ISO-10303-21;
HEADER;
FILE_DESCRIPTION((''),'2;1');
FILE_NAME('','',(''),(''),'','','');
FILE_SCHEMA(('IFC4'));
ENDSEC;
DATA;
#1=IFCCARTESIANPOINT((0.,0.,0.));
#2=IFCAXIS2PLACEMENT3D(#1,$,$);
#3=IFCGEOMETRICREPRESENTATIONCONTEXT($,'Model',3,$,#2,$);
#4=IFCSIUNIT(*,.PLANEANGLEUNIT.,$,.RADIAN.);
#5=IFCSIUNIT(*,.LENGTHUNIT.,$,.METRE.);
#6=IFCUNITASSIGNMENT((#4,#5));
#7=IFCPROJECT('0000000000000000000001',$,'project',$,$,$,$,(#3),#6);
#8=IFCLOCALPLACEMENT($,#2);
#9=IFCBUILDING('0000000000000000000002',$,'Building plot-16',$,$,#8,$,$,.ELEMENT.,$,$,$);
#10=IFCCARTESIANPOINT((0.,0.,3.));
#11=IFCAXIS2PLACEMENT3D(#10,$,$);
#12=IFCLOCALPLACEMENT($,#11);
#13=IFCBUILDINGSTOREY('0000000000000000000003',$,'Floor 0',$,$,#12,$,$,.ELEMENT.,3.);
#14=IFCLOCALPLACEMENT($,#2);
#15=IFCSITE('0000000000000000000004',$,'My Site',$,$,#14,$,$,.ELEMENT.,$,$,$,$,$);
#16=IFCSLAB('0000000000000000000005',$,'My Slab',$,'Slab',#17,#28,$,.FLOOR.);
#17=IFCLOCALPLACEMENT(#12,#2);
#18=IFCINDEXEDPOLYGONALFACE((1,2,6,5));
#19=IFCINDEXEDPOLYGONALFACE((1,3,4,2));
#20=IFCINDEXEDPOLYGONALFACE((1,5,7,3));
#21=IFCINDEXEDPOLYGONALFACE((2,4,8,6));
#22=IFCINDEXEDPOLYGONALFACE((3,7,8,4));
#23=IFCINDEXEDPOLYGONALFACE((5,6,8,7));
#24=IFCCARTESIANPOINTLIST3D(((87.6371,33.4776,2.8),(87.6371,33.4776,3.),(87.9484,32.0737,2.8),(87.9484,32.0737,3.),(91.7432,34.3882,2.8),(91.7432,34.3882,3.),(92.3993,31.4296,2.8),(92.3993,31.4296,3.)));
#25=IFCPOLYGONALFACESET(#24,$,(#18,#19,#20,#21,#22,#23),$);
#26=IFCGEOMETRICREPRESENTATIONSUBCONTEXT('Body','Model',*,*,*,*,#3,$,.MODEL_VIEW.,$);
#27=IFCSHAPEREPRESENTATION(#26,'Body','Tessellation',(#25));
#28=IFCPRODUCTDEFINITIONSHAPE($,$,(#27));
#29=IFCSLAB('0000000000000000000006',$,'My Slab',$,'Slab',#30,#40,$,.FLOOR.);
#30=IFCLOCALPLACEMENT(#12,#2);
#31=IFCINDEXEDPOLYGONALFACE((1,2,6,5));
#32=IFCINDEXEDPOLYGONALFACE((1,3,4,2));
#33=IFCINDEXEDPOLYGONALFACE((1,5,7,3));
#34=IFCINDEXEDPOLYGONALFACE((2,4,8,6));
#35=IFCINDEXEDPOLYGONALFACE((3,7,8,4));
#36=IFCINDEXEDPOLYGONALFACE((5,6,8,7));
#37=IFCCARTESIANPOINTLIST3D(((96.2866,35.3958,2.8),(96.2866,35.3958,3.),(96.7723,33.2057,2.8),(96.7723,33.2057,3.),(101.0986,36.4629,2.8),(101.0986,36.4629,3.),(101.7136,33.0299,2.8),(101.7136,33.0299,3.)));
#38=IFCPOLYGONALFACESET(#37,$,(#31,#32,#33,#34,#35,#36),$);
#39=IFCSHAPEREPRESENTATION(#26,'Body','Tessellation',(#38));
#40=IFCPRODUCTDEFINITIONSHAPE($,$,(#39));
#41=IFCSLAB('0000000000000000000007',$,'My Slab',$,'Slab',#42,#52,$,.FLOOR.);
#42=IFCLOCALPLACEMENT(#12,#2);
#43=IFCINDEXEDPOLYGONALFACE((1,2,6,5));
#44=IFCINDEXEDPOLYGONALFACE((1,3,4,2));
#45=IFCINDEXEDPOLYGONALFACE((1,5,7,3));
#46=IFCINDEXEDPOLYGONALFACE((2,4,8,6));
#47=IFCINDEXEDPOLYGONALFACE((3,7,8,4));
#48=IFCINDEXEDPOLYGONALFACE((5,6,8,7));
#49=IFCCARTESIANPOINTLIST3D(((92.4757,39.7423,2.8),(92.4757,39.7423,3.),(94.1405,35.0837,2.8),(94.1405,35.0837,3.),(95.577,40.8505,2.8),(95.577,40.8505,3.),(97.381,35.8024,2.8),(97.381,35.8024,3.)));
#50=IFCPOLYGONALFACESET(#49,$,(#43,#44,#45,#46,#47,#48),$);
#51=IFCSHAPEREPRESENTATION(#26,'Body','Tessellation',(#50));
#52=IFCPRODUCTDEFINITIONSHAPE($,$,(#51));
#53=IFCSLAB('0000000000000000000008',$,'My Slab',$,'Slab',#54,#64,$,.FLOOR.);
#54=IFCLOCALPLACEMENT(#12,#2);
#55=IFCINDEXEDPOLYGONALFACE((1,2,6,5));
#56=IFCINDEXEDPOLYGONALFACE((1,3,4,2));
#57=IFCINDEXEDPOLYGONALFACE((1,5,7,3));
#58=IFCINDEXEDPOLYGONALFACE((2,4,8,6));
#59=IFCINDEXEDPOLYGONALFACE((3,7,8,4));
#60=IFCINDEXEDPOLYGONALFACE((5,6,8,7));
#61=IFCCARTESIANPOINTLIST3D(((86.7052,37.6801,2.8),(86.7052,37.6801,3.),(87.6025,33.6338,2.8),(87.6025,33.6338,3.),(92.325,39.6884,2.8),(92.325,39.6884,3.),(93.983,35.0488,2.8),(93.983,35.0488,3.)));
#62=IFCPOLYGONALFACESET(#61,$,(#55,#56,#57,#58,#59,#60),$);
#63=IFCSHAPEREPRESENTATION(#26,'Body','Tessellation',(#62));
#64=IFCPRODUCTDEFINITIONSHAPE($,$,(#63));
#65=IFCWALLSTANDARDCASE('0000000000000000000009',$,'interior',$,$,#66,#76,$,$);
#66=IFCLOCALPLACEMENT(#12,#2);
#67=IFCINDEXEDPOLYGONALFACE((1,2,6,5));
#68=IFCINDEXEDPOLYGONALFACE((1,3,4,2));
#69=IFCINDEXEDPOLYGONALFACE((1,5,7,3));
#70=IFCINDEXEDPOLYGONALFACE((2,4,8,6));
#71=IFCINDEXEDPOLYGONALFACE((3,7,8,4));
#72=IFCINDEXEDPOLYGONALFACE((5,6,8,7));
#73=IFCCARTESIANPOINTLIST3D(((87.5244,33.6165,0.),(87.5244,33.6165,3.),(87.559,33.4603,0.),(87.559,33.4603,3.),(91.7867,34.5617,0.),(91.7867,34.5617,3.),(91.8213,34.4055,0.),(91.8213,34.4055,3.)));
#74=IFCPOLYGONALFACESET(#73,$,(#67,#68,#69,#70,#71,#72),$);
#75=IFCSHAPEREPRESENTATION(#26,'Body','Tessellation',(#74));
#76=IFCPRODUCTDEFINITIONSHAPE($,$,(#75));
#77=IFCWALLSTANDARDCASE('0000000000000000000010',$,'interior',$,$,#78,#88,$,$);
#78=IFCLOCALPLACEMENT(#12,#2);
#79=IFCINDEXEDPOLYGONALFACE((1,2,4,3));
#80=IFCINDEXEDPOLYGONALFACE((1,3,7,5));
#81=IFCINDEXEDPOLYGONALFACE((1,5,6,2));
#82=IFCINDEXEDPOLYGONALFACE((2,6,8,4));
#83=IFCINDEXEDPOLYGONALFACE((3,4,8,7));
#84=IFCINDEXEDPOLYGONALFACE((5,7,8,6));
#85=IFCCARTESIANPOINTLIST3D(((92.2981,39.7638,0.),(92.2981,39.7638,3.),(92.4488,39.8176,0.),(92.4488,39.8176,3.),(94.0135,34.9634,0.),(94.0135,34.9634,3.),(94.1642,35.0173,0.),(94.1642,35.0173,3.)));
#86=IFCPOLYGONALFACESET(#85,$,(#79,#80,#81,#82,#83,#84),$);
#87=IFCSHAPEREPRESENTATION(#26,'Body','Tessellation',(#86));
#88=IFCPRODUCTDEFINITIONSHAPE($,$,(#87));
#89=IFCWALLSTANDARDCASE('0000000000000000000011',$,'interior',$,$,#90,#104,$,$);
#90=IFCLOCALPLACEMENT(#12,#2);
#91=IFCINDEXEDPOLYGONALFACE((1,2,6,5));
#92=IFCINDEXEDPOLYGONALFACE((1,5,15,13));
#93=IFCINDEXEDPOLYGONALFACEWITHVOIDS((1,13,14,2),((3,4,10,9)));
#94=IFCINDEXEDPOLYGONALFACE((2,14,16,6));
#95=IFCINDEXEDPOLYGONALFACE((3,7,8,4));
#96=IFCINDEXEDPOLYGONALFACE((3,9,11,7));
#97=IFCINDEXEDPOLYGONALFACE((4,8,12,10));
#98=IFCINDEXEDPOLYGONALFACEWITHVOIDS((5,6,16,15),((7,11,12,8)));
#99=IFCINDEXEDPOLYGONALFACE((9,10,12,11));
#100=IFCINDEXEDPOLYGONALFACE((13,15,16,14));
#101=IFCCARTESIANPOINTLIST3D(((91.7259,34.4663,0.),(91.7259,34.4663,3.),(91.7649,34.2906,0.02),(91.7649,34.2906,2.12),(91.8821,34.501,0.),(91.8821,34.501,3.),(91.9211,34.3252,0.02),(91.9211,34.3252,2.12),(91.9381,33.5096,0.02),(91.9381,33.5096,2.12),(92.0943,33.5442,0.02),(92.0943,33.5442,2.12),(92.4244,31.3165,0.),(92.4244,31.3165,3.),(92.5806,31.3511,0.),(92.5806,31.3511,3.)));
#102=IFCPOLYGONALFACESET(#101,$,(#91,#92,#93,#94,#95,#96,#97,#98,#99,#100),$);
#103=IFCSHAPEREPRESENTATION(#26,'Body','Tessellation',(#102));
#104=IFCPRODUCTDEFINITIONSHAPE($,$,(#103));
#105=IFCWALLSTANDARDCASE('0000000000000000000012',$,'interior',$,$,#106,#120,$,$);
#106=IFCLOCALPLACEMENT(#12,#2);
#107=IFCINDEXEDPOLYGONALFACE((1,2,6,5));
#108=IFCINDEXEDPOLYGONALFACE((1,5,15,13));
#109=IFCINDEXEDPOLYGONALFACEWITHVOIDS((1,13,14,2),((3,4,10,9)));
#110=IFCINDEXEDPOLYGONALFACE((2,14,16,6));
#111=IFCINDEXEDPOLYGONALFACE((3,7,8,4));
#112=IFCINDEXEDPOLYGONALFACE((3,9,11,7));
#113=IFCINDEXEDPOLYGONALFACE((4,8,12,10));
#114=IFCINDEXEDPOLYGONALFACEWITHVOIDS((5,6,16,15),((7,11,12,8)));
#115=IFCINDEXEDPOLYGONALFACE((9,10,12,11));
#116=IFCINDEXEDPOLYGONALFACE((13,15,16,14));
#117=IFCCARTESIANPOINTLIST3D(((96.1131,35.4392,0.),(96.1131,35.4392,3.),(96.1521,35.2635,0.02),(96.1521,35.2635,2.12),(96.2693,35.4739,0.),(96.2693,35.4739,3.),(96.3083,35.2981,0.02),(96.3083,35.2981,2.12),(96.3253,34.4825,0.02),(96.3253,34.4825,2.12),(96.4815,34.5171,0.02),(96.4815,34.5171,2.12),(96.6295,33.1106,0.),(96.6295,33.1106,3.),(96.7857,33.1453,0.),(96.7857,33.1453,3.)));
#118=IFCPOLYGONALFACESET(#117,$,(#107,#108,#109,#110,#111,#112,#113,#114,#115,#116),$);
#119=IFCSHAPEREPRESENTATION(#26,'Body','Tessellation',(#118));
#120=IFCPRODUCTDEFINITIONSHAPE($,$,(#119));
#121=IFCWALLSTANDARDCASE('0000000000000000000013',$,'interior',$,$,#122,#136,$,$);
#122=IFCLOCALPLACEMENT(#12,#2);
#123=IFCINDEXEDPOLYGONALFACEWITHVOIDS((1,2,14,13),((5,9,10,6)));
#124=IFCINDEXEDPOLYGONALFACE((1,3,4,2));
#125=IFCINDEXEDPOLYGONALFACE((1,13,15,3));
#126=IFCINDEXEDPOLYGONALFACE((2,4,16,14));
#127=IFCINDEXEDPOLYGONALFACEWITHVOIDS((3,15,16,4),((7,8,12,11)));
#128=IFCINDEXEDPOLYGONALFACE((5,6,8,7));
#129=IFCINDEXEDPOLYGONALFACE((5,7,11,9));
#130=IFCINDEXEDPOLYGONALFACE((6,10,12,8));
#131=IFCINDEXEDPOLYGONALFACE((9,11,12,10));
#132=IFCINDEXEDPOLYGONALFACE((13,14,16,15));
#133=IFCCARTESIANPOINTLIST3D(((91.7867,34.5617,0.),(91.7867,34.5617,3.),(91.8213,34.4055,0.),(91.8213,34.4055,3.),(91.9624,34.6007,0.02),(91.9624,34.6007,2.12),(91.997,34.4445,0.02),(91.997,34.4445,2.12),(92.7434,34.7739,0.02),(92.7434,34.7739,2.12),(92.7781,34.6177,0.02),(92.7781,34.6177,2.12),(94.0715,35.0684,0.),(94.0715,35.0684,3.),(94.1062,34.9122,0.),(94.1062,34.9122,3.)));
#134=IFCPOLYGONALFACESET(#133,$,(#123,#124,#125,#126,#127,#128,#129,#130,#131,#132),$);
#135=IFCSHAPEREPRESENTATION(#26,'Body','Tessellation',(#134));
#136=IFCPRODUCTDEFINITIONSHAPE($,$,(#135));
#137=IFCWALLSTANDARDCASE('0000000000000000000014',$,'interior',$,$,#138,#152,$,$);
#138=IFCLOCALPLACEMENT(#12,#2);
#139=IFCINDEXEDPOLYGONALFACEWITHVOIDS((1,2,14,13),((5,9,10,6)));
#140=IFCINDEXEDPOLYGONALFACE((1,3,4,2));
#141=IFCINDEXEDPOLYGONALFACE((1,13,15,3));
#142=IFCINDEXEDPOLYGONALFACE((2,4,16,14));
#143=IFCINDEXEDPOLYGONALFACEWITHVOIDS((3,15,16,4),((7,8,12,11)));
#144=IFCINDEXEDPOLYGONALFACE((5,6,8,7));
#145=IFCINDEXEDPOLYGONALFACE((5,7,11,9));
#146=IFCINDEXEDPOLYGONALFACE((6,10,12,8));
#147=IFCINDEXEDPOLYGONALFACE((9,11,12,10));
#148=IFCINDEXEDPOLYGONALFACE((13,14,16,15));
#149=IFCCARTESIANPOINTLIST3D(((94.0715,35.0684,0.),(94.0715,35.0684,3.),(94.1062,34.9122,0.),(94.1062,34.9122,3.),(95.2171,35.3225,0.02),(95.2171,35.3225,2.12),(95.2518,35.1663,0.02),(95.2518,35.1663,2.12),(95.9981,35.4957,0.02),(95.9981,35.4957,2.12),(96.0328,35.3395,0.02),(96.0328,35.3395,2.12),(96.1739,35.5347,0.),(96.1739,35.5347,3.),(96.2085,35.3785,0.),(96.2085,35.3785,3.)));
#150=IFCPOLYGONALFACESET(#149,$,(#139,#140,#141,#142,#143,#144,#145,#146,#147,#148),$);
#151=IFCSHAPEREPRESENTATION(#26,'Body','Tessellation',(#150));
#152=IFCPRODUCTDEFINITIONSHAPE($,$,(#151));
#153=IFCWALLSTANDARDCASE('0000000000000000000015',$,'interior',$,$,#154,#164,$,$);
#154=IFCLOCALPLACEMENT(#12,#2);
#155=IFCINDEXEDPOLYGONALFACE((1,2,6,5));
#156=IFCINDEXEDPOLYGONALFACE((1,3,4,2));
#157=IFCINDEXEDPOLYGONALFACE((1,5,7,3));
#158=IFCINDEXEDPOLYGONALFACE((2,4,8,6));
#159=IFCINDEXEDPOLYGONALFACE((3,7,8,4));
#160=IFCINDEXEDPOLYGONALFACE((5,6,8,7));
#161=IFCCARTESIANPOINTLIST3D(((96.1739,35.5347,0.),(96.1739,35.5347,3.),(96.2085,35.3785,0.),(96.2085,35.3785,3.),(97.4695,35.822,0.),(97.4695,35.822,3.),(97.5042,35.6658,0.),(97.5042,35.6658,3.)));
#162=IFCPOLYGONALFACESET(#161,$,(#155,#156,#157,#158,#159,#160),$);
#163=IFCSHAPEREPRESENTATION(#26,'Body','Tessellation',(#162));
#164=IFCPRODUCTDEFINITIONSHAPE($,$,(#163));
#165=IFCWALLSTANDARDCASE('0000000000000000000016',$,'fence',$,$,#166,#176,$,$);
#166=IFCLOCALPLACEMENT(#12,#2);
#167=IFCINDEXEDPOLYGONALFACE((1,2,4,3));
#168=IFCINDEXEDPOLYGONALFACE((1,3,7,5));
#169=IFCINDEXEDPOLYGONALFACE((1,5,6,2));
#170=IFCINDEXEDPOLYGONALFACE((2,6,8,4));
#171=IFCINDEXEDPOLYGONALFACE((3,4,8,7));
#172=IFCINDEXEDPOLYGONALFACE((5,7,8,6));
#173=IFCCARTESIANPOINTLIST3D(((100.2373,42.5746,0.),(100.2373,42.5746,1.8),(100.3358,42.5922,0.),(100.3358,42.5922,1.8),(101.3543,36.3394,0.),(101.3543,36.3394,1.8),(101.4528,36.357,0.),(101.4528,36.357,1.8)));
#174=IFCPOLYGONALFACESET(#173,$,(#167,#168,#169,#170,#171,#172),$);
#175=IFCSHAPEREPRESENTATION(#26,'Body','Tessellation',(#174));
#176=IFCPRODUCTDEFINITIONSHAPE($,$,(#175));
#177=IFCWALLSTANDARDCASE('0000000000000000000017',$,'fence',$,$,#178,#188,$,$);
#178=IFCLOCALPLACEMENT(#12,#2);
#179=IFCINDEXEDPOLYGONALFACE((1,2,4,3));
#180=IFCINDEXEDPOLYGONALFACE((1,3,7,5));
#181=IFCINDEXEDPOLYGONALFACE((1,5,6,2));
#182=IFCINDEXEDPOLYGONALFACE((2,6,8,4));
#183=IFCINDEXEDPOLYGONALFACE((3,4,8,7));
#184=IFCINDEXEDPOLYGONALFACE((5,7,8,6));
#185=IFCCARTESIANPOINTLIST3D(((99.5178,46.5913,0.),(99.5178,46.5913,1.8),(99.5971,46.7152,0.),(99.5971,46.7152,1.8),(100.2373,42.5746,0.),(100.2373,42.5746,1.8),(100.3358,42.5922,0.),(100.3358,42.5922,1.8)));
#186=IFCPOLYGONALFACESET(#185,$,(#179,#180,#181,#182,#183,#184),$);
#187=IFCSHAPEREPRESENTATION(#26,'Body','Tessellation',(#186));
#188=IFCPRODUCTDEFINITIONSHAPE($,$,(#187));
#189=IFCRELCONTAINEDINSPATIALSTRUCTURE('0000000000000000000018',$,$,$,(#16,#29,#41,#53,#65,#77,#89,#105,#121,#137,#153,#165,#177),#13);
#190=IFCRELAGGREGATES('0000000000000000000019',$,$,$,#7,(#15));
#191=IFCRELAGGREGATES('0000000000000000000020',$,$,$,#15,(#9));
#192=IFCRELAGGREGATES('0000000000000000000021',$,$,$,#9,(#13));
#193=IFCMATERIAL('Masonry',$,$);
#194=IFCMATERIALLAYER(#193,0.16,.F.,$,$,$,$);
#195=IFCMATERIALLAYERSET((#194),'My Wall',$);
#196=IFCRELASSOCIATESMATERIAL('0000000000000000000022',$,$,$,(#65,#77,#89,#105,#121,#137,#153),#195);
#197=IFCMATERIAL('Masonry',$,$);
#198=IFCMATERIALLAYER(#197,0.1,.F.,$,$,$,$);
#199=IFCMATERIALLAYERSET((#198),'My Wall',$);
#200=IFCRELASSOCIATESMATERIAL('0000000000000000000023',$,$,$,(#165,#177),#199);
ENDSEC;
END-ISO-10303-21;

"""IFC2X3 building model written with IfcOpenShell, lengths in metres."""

from ifc_helpers import new_model, si_unit, frame, origin, place, context, subcontext, project, spatial, polyline, outline, extrude, material, layer, layer_set, layer_usage, element, save


model = new_model("IFC2X3")

# Units and contexts
model_context = context("Model", 3, world=origin())
body_context = subcontext(model_context, "Body", "Model", "MODEL_VIEW")
ifc_project = project(units=[si_unit("PLANEANGLEUNIT", "RADIAN"), si_unit("LENGTHUNIT", "METRE")], contexts=[model_context])

# Site, building, storey
site_placement = place(None, origin())
site = spatial("IfcSite", under=ifc_project, at=site_placement, Name="My Site", CompositionType="ELEMENT")
building_placement = place(None, origin())
building = spatial("IfcBuilding", under=site, at=building_placement, Name="Building plot-16", CompositionType="ELEMENT")
storey_placement = place(None, frame((0.0, 0.0, 3.0)))
storey = spatial("IfcBuildingStorey", under=building, at=storey_placement, Name="Floor 0", CompositionType="ELEMENT", Elevation=3.0)

# Slabs
slab_1_placement = place(storey_placement, frame((0.0, 0.0, 2.8)))
element("IfcSlab", 1, at=slab_1_placement, inside=storey, Name="My Slab", ObjectType="Slab", PredefinedType="FLOOR", context=body_context, shape_type="SweptSolid", body=[
    extrude(outline(polyline([(91.7432, 34.3882), (87.6371, 33.4776), (87.9484, 32.0737), (92.3993, 31.4296), (91.7432, 34.3882)])), origin(), (0.0, 0.0, 1.0), 0.2),
])
slab_2_placement = place(storey_placement, frame((0.0, 0.0, 2.8)))
element("IfcSlab", 2, at=slab_2_placement, inside=storey, Name="My Slab", ObjectType="Slab", PredefinedType="FLOOR", context=body_context, shape_type="SweptSolid", body=[
    extrude(outline(polyline([(96.2866, 35.3958), (96.7723, 33.2057), (101.7136, 33.0299), (101.0986, 36.4629), (96.2866, 35.3958)])), origin(), (0.0, 0.0, 1.0), 0.2),
])
slab_3_placement = place(storey_placement, frame((0.0, 0.0, 2.8)))
element("IfcSlab", 3, at=slab_3_placement, inside=storey, Name="My Slab", ObjectType="Slab", PredefinedType="FLOOR", context=body_context, shape_type="SweptSolid", body=[
    extrude(outline(polyline([(94.1405, 35.0837), (97.381, 35.8024), (95.577, 40.8505), (92.4757, 39.7423), (94.1405, 35.0837)])), origin(), (0.0, 0.0, 1.0), 0.2),
])
slab_4_placement = place(storey_placement, frame((0.0, 0.0, 2.8)))
element("IfcSlab", 4, at=slab_4_placement, inside=storey, Name="My Slab", ObjectType="Slab", PredefinedType="FLOOR", context=body_context, shape_type="SweptSolid", body=[
    extrude(outline(polyline([(87.6025, 33.6338), (93.983, 35.0488), (92.325, 39.6884), (86.7052, 37.6801), (87.6025, 33.6338)])), origin(), (0.0, 0.0, 1.0), 0.2),
])

# Walls
ifc_material_1 = material(Name="Masonry")
ifc_layer_1 = layer(ifc_material_1, 0.16, ventilated=False)
ifc_layer_set_1 = layer_set([ifc_layer_1], Name="My Wall")
ifc_layer_usage_1 = layer_usage(ifc_layer_set_1, "AXIS2", "NEGATIVE", 0.08)
wall_1_placement = place(storey_placement, origin())
element("IfcWallStandardCase", 5, at=wall_1_placement, inside=storey, material=ifc_layer_usage_1, Name="interior", context=body_context, shape_type="SweptSolid", body=[
    extrude(outline(polyline([(91.8213, 34.4055), (91.7867, 34.5617), (87.5244, 33.6165), (87.559, 33.4603), (91.8213, 34.4055)])), origin(), (0.0, 0.0, 1.0), 3.0),
])
wall_2_placement = place(storey_placement, origin())
element("IfcWallStandardCase", 6, at=wall_2_placement, inside=storey, material=ifc_layer_usage_1, Name="interior", context=body_context, shape_type="SweptSolid", body=[
    extrude(outline(polyline([(92.4488, 39.8176), (92.2981, 39.7638), (94.0135, 34.9634), (94.1642, 35.0173), (92.4488, 39.8176)])), origin(), (0.0, 0.0, 1.0), 3.0),
])

# Walls, openings
wall_3_placement = place(storey_placement, origin())
wall_3 = element("IfcWallStandardCase", 7, at=wall_3_placement, inside=storey, material=ifc_layer_usage_1, Name="interior", context=body_context, shape_type="SweptSolid", body=[
    extrude(outline(polyline([(91.8821, 34.501), (91.7259, 34.4663), (92.4244, 31.3165), (92.5806, 31.3511), (91.8821, 34.501)])), origin(), (0.0, 0.0, 1.0), 3.0),
])
opening_1_placement = place(storey_placement, frame((0.0, 0.0, 0.02)))
element("IfcOpeningElement", 8, at=opening_1_placement, cuts=wall_3, ObjectType="Opening", context=body_context, shape_type="SweptSolid", body=[
    extrude(outline(polyline([(91.7649, 34.2906), (91.9381, 33.5096), (92.0943, 33.5442), (91.9211, 34.3252), (91.7649, 34.2906)])), origin(), (0.0, 0.0, 1.0), 2.1),
])
wall_4_placement = place(storey_placement, origin())
wall_4 = element("IfcWallStandardCase", 9, at=wall_4_placement, inside=storey, material=ifc_layer_usage_1, Name="interior", context=body_context, shape_type="SweptSolid", body=[
    extrude(outline(polyline([(96.2693, 35.4739), (96.1131, 35.4392), (96.6295, 33.1106), (96.7857, 33.1453), (96.2693, 35.4739)])), origin(), (0.0, 0.0, 1.0), 3.0),
])
opening_2_placement = place(storey_placement, frame((0.0, 0.0, 0.02)))
element("IfcOpeningElement", 10, at=opening_2_placement, cuts=wall_4, ObjectType="Opening", context=body_context, shape_type="SweptSolid", body=[
    extrude(outline(polyline([(96.1521, 35.2635), (96.3253, 34.4825), (96.4815, 34.5171), (96.3083, 35.2981), (96.1521, 35.2635)])), origin(), (0.0, 0.0, 1.0), 2.1),
])
wall_5_placement = place(storey_placement, origin())
wall_5 = element("IfcWallStandardCase", 11, at=wall_5_placement, inside=storey, material=ifc_layer_usage_1, Name="interior", context=body_context, shape_type="SweptSolid", body=[
    extrude(outline(polyline([(94.1062, 34.9122), (94.0715, 35.0684), (91.7867, 34.5617), (91.8213, 34.4055), (94.1062, 34.9122)])), origin(), (0.0, 0.0, 1.0), 3.0),
])
opening_3_placement = place(storey_placement, frame((0.0, 0.0, 0.02)))
element("IfcOpeningElement", 12, at=opening_3_placement, cuts=wall_5, ObjectType="Opening", context=body_context, shape_type="SweptSolid", body=[
    extrude(outline(polyline([(92.7434, 34.7739), (91.9624, 34.6007), (91.997, 34.4445), (92.7781, 34.6177), (92.7434, 34.7739)])), origin(), (0.0, 0.0, 1.0), 2.1),
])
wall_6_placement = place(storey_placement, origin())
wall_6 = element("IfcWallStandardCase", 13, at=wall_6_placement, inside=storey, material=ifc_layer_usage_1, Name="interior", context=body_context, shape_type="SweptSolid", body=[
    extrude(outline(polyline([(94.0715, 35.0684), (94.1062, 34.9122), (96.2085, 35.3785), (96.1739, 35.5347), (94.0715, 35.0684)])), origin(), (0.0, 0.0, 1.0), 3.0),
])
opening_4_placement = place(storey_placement, frame((0.0, 0.0, 0.02)))
element("IfcOpeningElement", 14, at=opening_4_placement, cuts=wall_6, ObjectType="Opening", context=body_context, shape_type="SweptSolid", body=[
    extrude(outline(polyline([(95.2518, 35.1663), (96.0328, 35.3395), (95.9981, 35.4957), (95.2171, 35.3225), (95.2518, 35.1663)])), origin(), (0.0, 0.0, 1.0), 2.1),
])

# Walls
wall_7_placement = place(storey_placement, origin())
element("IfcWallStandardCase", 15, at=wall_7_placement, inside=storey, material=ifc_layer_usage_1, Name="interior", context=body_context, shape_type="SweptSolid", body=[
    extrude(outline(polyline([(96.1739, 35.5347), (96.2085, 35.3785), (97.5042, 35.6658), (97.4695, 35.822), (96.1739, 35.5347)])), origin(), (0.0, 0.0, 1.0), 3.0),
])
ifc_material_2 = material(Name="Masonry")
ifc_layer_2 = layer(ifc_material_2, 0.1, ventilated=False)
ifc_layer_set_2 = layer_set([ifc_layer_2], Name="My Wall")
ifc_layer_usage_2 = layer_usage(ifc_layer_set_2, "AXIS2", "NEGATIVE", -0.15)
wall_8_placement = place(storey_placement, origin())
element("IfcWallStandardCase", 16, at=wall_8_placement, inside=storey, material=ifc_layer_usage_2, Name="fence", context=body_context, shape_type="SweptSolid", body=[
    extrude(outline(polyline([(101.3543, 36.3394), (101.4528, 36.357), (100.3358, 42.5922), (100.2373, 42.5746), (101.3543, 36.3394)])), origin(), (0.0, 0.0, 1.0), 1.8),
])
wall_9_placement = place(storey_placement, origin())
element("IfcWallStandardCase", 17, at=wall_9_placement, inside=storey, material=ifc_layer_usage_2, Name="fence", context=body_context, shape_type="SweptSolid", body=[
    extrude(outline(polyline([(100.2373, 42.5746), (100.3358, 42.5922), (99.5971, 46.7152), (99.5178, 46.5913), (100.2373, 42.5746)])), origin(), (0.0, 0.0, 1.0), 1.8),
])

save(model, "model.ifc")
